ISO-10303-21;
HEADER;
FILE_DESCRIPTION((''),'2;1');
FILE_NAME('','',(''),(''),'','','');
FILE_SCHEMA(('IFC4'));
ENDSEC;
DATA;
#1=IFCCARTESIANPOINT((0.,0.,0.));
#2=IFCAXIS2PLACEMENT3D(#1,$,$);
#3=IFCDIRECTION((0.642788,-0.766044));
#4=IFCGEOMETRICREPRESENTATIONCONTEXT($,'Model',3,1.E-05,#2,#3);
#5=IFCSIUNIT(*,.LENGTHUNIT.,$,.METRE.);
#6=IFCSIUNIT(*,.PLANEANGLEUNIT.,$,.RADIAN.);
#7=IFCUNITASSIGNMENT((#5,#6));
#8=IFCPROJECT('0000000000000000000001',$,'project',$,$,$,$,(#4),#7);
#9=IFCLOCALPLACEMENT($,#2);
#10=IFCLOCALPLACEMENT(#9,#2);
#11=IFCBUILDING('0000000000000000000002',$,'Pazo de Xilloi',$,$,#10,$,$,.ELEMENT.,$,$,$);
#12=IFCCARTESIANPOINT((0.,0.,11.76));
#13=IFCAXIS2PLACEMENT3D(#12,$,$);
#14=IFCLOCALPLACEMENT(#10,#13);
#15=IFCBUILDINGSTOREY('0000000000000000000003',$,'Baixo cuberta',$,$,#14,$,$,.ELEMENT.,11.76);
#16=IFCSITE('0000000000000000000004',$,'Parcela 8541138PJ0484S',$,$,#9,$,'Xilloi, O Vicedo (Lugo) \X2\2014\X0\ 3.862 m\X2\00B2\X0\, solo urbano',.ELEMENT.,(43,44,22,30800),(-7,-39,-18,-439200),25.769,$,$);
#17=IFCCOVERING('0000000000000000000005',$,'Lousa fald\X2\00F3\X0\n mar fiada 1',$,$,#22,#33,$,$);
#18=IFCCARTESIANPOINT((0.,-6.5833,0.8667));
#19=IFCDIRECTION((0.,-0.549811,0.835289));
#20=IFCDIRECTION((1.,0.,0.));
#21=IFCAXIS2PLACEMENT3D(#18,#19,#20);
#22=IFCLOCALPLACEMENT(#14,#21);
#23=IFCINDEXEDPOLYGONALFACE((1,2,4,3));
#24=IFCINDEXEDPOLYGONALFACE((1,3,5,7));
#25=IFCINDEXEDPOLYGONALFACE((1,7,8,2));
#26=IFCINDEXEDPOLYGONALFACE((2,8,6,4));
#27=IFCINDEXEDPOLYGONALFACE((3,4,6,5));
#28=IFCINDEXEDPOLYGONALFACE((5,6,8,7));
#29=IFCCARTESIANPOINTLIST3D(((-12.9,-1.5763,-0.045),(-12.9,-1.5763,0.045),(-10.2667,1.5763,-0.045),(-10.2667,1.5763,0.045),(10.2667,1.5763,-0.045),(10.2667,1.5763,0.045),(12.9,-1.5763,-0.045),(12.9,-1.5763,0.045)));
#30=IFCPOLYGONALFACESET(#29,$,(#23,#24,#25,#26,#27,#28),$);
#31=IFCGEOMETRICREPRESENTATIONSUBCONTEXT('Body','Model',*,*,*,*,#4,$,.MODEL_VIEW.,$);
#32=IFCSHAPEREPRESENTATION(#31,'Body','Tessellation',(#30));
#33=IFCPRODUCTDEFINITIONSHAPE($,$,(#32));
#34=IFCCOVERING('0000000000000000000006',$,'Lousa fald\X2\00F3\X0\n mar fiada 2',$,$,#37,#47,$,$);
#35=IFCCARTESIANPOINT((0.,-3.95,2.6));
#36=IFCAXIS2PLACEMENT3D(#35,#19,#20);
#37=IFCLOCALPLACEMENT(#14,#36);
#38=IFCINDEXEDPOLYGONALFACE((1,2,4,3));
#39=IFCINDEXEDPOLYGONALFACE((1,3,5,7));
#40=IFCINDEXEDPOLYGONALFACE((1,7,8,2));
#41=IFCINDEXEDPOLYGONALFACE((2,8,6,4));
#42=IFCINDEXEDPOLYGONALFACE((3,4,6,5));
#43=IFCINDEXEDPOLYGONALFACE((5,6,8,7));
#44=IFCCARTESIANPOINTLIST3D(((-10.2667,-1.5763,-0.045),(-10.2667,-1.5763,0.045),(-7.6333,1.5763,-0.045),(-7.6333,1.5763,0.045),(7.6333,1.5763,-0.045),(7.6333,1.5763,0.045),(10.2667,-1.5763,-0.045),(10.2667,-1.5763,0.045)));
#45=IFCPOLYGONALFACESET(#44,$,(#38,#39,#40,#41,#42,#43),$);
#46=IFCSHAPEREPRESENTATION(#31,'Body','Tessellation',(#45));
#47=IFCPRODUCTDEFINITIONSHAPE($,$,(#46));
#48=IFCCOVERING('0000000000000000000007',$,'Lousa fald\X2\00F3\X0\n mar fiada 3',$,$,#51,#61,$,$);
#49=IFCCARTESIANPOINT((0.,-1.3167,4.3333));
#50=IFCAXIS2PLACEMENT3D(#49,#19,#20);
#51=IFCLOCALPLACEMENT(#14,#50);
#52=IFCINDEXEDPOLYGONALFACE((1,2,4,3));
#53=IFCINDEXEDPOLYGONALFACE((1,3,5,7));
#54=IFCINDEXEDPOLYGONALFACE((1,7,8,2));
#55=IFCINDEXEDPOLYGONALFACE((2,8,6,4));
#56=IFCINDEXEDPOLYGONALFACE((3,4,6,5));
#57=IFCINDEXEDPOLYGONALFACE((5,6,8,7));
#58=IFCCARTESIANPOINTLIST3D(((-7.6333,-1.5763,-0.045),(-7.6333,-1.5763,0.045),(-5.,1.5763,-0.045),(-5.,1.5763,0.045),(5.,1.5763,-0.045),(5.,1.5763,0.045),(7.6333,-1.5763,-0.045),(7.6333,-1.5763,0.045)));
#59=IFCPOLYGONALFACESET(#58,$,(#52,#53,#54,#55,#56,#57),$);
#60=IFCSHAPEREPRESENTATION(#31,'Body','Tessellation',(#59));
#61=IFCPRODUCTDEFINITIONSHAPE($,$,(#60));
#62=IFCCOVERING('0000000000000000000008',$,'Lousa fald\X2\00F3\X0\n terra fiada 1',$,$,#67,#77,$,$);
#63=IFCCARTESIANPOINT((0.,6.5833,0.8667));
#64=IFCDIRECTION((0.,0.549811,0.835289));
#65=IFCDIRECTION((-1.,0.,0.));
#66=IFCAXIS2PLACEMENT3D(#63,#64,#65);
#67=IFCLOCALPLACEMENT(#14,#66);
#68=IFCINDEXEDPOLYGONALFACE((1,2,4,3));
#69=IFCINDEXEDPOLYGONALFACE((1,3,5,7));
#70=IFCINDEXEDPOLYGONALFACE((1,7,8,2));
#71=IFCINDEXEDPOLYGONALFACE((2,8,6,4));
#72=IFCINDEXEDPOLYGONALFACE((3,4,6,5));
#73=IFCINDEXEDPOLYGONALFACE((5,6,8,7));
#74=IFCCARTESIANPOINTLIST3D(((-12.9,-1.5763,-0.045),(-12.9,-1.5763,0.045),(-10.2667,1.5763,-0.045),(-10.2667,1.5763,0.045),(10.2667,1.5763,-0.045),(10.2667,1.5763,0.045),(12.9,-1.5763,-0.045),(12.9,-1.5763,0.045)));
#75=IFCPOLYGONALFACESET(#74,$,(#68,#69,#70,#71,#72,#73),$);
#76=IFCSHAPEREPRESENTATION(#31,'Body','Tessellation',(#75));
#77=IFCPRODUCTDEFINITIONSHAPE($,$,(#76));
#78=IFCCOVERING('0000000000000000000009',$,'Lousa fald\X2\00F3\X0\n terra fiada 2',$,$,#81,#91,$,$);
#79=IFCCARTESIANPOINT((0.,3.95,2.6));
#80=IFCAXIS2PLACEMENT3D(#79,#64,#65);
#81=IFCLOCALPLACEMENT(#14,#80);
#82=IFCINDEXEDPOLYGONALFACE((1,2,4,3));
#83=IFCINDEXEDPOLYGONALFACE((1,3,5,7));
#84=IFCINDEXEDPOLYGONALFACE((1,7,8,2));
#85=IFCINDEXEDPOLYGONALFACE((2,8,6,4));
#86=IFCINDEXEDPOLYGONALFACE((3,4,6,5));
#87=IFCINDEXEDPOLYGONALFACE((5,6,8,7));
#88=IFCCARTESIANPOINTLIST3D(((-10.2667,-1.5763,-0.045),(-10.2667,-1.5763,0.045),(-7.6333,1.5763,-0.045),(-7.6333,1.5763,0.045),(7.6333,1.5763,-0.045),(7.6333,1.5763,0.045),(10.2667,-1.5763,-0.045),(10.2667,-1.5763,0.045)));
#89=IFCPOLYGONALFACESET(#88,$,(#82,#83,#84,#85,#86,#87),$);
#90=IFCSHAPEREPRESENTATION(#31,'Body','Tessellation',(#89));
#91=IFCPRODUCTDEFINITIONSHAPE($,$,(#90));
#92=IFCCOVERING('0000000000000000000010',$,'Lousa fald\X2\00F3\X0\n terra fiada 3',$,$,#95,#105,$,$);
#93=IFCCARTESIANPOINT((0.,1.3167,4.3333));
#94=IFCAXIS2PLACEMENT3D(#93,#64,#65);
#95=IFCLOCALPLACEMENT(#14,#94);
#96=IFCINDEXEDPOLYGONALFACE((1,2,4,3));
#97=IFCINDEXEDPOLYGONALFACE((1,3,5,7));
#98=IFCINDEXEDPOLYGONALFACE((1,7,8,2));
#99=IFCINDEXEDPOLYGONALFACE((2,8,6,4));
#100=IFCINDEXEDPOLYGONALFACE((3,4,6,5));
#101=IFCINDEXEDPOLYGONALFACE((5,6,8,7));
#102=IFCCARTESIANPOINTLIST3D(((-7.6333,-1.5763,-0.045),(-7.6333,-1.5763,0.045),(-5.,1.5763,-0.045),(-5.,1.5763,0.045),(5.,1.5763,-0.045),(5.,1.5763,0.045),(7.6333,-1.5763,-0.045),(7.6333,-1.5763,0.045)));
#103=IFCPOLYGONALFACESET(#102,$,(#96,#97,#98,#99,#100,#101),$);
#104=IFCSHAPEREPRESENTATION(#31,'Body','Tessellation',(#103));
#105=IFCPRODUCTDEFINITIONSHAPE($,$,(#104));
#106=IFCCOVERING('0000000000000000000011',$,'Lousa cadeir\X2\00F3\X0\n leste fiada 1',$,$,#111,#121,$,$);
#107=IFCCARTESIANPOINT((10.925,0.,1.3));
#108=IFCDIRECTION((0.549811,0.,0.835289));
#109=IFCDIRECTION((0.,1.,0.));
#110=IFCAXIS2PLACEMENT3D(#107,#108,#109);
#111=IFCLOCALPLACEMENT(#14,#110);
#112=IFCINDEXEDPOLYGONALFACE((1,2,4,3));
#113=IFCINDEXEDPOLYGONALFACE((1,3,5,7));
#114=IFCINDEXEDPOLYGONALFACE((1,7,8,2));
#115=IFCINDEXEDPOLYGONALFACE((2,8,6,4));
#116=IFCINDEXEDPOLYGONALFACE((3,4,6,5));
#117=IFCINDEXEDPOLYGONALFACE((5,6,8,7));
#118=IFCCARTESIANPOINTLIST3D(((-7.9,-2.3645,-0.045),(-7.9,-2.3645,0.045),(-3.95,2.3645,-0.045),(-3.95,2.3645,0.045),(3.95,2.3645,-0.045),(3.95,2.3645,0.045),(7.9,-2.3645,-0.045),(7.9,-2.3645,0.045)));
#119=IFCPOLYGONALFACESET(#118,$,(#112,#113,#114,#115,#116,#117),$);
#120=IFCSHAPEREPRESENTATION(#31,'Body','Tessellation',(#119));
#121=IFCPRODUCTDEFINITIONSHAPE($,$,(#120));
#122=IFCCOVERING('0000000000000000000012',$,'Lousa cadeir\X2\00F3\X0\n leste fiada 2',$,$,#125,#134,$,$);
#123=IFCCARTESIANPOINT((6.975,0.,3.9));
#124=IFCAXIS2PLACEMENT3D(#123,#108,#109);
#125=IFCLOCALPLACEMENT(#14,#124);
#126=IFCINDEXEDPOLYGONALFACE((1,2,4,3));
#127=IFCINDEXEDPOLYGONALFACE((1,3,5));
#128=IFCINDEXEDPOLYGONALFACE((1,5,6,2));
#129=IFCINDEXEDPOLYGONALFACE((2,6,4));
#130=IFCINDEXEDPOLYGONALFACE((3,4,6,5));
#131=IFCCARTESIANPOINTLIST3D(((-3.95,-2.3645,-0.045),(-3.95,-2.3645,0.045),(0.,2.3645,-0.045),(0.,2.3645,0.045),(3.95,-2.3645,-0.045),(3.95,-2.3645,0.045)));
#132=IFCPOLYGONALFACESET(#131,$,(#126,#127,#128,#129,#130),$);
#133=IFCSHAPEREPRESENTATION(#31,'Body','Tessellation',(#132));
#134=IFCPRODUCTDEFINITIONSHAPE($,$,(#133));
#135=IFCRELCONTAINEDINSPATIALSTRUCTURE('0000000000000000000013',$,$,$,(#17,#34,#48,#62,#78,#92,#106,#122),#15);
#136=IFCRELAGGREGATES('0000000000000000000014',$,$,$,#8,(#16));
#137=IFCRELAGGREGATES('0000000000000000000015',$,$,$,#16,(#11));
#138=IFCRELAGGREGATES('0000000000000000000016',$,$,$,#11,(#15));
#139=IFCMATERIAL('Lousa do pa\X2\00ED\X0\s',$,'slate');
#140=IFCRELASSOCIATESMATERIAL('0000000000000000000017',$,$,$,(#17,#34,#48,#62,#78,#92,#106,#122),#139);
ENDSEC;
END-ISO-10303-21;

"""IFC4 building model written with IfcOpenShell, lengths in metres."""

from ifc_helpers import new_model, si_unit, direction, frame, origin, place, context, subcontext, project, spatial, polyline, outline, extrude, material, element, save


model = new_model("IFC4")

# Units and contexts
model_context = context("Model", 3, precision=1e-05, world=origin(), true_north=direction((0.642788, -0.766044)))
body_context = subcontext(model_context, "Body", "Model", "MODEL_VIEW")
ifc_project = project(units=[si_unit("LENGTHUNIT", "METRE"), si_unit("PLANEANGLEUNIT", "RADIAN")], contexts=[model_context])

# Site, building, storey
site_placement = place(None, origin())
site = spatial("IfcSite", under=ifc_project, at=site_placement, Name="Parcela 8541138PJ0484S", LongName="Xilloi, O Vicedo (Lugo) — 3.862 m², solo urbano", CompositionType="ELEMENT", RefLatitude=(43, 44, 22, 30800), RefLongitude=(-7, -39, -18, -439200), RefElevation=25.769)
building_placement = place(site_placement, origin())
building = spatial("IfcBuilding", under=site, at=building_placement, Name="Pazo de Xilloi", CompositionType="ELEMENT")
storey_placement = place(building_placement, frame((0.0, 0.0, 11.76)))
storey = spatial("IfcBuildingStorey", under=building, at=storey_placement, Name="Baixo cuberta", CompositionType="ELEMENT", Elevation=11.76)

# Shared definitions
ifc_material_1 = material(Name="Lousa do país", Category="slate")

# Coverings
covering_1_placement = place(storey_placement, frame((0.0, -6.5833, 0.8667), z_axis=(0.0, -0.549811, 0.835289), x_axis=(1.0, 0.0, 0.0)))
element("IfcCovering", 1, at=covering_1_placement, inside=storey, material=ifc_material_1, Name="Lousa faldón mar fiada 1", context=body_context, shape_type="SweptSolid", body=[
    extrude(outline(polyline([(-12.9, -1.5763), (12.9, -1.5763), (10.2667, 1.5763), (-10.2667, 1.5763), (-12.9, -1.5763)])), frame((0.0, 0.0, -0.045)), (0.0, 0.0, 1.0), 0.09),
])
covering_2_placement = place(storey_placement, frame((0.0, -3.95, 2.6), z_axis=(0.0, -0.549811, 0.835289), x_axis=(1.0, 0.0, 0.0)))
element("IfcCovering", 2, at=covering_2_placement, inside=storey, material=ifc_material_1, Name="Lousa faldón mar fiada 2", context=body_context, shape_type="SweptSolid", body=[
    extrude(outline(polyline([(-10.2667, -1.5763), (10.2667, -1.5763), (7.6333, 1.5763), (-7.6333, 1.5763), (-10.2667, -1.5763)])), frame((0.0, 0.0, -0.045)), (0.0, 0.0, 1.0), 0.09),
])
covering_3_placement = place(storey_placement, frame((0.0, -1.3167, 4.3333), z_axis=(0.0, -0.549811, 0.835289), x_axis=(1.0, 0.0, 0.0)))
element("IfcCovering", 3, at=covering_3_placement, inside=storey, material=ifc_material_1, Name="Lousa faldón mar fiada 3", context=body_context, shape_type="SweptSolid", body=[
    extrude(outline(polyline([(-7.6333, -1.5763), (7.6333, -1.5763), (5.0, 1.5763), (-5.0, 1.5763), (-7.6333, -1.5763)])), frame((0.0, 0.0, -0.045)), (0.0, 0.0, 1.0), 0.09),
])
covering_4_placement = place(storey_placement, frame((0.0, 6.5833, 0.8667), z_axis=(0.0, 0.549811, 0.835289), x_axis=(-1.0, 0.0, 0.0)))
element("IfcCovering", 4, at=covering_4_placement, inside=storey, material=ifc_material_1, Name="Lousa faldón terra fiada 1", context=body_context, shape_type="SweptSolid", body=[
    extrude(outline(polyline([(-12.9, -1.5763), (12.9, -1.5763), (10.2667, 1.5763), (-10.2667, 1.5763), (-12.9, -1.5763)])), frame((0.0, 0.0, -0.045)), (0.0, 0.0, 1.0), 0.09),
])
covering_5_placement = place(storey_placement, frame((0.0, 3.95, 2.6), z_axis=(0.0, 0.549811, 0.835289), x_axis=(-1.0, 0.0, 0.0)))
element("IfcCovering", 5, at=covering_5_placement, inside=storey, material=ifc_material_1, Name="Lousa faldón terra fiada 2", context=body_context, shape_type="SweptSolid", body=[
    extrude(outline(polyline([(-10.2667, -1.5763), (10.2667, -1.5763), (7.6333, 1.5763), (-7.6333, 1.5763), (-10.2667, -1.5763)])), frame((0.0, 0.0, -0.045)), (0.0, 0.0, 1.0), 0.09),
])
covering_6_placement = place(storey_placement, frame((0.0, 1.3167, 4.3333), z_axis=(0.0, 0.549811, 0.835289), x_axis=(-1.0, 0.0, 0.0)))
element("IfcCovering", 6, at=covering_6_placement, inside=storey, material=ifc_material_1, Name="Lousa faldón terra fiada 3", context=body_context, shape_type="SweptSolid", body=[
    extrude(outline(polyline([(-7.6333, -1.5763), (7.6333, -1.5763), (5.0, 1.5763), (-5.0, 1.5763), (-7.6333, -1.5763)])), frame((0.0, 0.0, -0.045)), (0.0, 0.0, 1.0), 0.09),
])
covering_7_placement = place(storey_placement, frame((10.925, 0.0, 1.3), z_axis=(0.549811, 0.0, 0.835289), x_axis=(0.0, 1.0, 0.0)))
element("IfcCovering", 7, at=covering_7_placement, inside=storey, material=ifc_material_1, Name="Lousa cadeirón leste fiada 1", context=body_context, shape_type="SweptSolid", body=[
    extrude(outline(polyline([(-7.9, -2.3645), (7.9, -2.3645), (3.95, 2.3645), (-3.95, 2.3645), (-7.9, -2.3645)])), frame((0.0, 0.0, -0.045)), (0.0, 0.0, 1.0), 0.09),
])
covering_8_placement = place(storey_placement, frame((6.975, 0.0, 3.9), z_axis=(0.549811, 0.0, 0.835289), x_axis=(0.0, 1.0, 0.0)))
element("IfcCovering", 8, at=covering_8_placement, inside=storey, material=ifc_material_1, Name="Lousa cadeirón leste fiada 2", context=body_context, shape_type="SweptSolid", body=[
    extrude(outline(polyline([(-3.95, -2.3645), (3.95, -2.3645), (0.0, 2.3645), (0.0, 2.3645), (-3.95, -2.3645)])), frame((0.0, 0.0, -0.045)), (0.0, 0.0, 1.0), 0.09),
])

save(model, "model.ifc")
